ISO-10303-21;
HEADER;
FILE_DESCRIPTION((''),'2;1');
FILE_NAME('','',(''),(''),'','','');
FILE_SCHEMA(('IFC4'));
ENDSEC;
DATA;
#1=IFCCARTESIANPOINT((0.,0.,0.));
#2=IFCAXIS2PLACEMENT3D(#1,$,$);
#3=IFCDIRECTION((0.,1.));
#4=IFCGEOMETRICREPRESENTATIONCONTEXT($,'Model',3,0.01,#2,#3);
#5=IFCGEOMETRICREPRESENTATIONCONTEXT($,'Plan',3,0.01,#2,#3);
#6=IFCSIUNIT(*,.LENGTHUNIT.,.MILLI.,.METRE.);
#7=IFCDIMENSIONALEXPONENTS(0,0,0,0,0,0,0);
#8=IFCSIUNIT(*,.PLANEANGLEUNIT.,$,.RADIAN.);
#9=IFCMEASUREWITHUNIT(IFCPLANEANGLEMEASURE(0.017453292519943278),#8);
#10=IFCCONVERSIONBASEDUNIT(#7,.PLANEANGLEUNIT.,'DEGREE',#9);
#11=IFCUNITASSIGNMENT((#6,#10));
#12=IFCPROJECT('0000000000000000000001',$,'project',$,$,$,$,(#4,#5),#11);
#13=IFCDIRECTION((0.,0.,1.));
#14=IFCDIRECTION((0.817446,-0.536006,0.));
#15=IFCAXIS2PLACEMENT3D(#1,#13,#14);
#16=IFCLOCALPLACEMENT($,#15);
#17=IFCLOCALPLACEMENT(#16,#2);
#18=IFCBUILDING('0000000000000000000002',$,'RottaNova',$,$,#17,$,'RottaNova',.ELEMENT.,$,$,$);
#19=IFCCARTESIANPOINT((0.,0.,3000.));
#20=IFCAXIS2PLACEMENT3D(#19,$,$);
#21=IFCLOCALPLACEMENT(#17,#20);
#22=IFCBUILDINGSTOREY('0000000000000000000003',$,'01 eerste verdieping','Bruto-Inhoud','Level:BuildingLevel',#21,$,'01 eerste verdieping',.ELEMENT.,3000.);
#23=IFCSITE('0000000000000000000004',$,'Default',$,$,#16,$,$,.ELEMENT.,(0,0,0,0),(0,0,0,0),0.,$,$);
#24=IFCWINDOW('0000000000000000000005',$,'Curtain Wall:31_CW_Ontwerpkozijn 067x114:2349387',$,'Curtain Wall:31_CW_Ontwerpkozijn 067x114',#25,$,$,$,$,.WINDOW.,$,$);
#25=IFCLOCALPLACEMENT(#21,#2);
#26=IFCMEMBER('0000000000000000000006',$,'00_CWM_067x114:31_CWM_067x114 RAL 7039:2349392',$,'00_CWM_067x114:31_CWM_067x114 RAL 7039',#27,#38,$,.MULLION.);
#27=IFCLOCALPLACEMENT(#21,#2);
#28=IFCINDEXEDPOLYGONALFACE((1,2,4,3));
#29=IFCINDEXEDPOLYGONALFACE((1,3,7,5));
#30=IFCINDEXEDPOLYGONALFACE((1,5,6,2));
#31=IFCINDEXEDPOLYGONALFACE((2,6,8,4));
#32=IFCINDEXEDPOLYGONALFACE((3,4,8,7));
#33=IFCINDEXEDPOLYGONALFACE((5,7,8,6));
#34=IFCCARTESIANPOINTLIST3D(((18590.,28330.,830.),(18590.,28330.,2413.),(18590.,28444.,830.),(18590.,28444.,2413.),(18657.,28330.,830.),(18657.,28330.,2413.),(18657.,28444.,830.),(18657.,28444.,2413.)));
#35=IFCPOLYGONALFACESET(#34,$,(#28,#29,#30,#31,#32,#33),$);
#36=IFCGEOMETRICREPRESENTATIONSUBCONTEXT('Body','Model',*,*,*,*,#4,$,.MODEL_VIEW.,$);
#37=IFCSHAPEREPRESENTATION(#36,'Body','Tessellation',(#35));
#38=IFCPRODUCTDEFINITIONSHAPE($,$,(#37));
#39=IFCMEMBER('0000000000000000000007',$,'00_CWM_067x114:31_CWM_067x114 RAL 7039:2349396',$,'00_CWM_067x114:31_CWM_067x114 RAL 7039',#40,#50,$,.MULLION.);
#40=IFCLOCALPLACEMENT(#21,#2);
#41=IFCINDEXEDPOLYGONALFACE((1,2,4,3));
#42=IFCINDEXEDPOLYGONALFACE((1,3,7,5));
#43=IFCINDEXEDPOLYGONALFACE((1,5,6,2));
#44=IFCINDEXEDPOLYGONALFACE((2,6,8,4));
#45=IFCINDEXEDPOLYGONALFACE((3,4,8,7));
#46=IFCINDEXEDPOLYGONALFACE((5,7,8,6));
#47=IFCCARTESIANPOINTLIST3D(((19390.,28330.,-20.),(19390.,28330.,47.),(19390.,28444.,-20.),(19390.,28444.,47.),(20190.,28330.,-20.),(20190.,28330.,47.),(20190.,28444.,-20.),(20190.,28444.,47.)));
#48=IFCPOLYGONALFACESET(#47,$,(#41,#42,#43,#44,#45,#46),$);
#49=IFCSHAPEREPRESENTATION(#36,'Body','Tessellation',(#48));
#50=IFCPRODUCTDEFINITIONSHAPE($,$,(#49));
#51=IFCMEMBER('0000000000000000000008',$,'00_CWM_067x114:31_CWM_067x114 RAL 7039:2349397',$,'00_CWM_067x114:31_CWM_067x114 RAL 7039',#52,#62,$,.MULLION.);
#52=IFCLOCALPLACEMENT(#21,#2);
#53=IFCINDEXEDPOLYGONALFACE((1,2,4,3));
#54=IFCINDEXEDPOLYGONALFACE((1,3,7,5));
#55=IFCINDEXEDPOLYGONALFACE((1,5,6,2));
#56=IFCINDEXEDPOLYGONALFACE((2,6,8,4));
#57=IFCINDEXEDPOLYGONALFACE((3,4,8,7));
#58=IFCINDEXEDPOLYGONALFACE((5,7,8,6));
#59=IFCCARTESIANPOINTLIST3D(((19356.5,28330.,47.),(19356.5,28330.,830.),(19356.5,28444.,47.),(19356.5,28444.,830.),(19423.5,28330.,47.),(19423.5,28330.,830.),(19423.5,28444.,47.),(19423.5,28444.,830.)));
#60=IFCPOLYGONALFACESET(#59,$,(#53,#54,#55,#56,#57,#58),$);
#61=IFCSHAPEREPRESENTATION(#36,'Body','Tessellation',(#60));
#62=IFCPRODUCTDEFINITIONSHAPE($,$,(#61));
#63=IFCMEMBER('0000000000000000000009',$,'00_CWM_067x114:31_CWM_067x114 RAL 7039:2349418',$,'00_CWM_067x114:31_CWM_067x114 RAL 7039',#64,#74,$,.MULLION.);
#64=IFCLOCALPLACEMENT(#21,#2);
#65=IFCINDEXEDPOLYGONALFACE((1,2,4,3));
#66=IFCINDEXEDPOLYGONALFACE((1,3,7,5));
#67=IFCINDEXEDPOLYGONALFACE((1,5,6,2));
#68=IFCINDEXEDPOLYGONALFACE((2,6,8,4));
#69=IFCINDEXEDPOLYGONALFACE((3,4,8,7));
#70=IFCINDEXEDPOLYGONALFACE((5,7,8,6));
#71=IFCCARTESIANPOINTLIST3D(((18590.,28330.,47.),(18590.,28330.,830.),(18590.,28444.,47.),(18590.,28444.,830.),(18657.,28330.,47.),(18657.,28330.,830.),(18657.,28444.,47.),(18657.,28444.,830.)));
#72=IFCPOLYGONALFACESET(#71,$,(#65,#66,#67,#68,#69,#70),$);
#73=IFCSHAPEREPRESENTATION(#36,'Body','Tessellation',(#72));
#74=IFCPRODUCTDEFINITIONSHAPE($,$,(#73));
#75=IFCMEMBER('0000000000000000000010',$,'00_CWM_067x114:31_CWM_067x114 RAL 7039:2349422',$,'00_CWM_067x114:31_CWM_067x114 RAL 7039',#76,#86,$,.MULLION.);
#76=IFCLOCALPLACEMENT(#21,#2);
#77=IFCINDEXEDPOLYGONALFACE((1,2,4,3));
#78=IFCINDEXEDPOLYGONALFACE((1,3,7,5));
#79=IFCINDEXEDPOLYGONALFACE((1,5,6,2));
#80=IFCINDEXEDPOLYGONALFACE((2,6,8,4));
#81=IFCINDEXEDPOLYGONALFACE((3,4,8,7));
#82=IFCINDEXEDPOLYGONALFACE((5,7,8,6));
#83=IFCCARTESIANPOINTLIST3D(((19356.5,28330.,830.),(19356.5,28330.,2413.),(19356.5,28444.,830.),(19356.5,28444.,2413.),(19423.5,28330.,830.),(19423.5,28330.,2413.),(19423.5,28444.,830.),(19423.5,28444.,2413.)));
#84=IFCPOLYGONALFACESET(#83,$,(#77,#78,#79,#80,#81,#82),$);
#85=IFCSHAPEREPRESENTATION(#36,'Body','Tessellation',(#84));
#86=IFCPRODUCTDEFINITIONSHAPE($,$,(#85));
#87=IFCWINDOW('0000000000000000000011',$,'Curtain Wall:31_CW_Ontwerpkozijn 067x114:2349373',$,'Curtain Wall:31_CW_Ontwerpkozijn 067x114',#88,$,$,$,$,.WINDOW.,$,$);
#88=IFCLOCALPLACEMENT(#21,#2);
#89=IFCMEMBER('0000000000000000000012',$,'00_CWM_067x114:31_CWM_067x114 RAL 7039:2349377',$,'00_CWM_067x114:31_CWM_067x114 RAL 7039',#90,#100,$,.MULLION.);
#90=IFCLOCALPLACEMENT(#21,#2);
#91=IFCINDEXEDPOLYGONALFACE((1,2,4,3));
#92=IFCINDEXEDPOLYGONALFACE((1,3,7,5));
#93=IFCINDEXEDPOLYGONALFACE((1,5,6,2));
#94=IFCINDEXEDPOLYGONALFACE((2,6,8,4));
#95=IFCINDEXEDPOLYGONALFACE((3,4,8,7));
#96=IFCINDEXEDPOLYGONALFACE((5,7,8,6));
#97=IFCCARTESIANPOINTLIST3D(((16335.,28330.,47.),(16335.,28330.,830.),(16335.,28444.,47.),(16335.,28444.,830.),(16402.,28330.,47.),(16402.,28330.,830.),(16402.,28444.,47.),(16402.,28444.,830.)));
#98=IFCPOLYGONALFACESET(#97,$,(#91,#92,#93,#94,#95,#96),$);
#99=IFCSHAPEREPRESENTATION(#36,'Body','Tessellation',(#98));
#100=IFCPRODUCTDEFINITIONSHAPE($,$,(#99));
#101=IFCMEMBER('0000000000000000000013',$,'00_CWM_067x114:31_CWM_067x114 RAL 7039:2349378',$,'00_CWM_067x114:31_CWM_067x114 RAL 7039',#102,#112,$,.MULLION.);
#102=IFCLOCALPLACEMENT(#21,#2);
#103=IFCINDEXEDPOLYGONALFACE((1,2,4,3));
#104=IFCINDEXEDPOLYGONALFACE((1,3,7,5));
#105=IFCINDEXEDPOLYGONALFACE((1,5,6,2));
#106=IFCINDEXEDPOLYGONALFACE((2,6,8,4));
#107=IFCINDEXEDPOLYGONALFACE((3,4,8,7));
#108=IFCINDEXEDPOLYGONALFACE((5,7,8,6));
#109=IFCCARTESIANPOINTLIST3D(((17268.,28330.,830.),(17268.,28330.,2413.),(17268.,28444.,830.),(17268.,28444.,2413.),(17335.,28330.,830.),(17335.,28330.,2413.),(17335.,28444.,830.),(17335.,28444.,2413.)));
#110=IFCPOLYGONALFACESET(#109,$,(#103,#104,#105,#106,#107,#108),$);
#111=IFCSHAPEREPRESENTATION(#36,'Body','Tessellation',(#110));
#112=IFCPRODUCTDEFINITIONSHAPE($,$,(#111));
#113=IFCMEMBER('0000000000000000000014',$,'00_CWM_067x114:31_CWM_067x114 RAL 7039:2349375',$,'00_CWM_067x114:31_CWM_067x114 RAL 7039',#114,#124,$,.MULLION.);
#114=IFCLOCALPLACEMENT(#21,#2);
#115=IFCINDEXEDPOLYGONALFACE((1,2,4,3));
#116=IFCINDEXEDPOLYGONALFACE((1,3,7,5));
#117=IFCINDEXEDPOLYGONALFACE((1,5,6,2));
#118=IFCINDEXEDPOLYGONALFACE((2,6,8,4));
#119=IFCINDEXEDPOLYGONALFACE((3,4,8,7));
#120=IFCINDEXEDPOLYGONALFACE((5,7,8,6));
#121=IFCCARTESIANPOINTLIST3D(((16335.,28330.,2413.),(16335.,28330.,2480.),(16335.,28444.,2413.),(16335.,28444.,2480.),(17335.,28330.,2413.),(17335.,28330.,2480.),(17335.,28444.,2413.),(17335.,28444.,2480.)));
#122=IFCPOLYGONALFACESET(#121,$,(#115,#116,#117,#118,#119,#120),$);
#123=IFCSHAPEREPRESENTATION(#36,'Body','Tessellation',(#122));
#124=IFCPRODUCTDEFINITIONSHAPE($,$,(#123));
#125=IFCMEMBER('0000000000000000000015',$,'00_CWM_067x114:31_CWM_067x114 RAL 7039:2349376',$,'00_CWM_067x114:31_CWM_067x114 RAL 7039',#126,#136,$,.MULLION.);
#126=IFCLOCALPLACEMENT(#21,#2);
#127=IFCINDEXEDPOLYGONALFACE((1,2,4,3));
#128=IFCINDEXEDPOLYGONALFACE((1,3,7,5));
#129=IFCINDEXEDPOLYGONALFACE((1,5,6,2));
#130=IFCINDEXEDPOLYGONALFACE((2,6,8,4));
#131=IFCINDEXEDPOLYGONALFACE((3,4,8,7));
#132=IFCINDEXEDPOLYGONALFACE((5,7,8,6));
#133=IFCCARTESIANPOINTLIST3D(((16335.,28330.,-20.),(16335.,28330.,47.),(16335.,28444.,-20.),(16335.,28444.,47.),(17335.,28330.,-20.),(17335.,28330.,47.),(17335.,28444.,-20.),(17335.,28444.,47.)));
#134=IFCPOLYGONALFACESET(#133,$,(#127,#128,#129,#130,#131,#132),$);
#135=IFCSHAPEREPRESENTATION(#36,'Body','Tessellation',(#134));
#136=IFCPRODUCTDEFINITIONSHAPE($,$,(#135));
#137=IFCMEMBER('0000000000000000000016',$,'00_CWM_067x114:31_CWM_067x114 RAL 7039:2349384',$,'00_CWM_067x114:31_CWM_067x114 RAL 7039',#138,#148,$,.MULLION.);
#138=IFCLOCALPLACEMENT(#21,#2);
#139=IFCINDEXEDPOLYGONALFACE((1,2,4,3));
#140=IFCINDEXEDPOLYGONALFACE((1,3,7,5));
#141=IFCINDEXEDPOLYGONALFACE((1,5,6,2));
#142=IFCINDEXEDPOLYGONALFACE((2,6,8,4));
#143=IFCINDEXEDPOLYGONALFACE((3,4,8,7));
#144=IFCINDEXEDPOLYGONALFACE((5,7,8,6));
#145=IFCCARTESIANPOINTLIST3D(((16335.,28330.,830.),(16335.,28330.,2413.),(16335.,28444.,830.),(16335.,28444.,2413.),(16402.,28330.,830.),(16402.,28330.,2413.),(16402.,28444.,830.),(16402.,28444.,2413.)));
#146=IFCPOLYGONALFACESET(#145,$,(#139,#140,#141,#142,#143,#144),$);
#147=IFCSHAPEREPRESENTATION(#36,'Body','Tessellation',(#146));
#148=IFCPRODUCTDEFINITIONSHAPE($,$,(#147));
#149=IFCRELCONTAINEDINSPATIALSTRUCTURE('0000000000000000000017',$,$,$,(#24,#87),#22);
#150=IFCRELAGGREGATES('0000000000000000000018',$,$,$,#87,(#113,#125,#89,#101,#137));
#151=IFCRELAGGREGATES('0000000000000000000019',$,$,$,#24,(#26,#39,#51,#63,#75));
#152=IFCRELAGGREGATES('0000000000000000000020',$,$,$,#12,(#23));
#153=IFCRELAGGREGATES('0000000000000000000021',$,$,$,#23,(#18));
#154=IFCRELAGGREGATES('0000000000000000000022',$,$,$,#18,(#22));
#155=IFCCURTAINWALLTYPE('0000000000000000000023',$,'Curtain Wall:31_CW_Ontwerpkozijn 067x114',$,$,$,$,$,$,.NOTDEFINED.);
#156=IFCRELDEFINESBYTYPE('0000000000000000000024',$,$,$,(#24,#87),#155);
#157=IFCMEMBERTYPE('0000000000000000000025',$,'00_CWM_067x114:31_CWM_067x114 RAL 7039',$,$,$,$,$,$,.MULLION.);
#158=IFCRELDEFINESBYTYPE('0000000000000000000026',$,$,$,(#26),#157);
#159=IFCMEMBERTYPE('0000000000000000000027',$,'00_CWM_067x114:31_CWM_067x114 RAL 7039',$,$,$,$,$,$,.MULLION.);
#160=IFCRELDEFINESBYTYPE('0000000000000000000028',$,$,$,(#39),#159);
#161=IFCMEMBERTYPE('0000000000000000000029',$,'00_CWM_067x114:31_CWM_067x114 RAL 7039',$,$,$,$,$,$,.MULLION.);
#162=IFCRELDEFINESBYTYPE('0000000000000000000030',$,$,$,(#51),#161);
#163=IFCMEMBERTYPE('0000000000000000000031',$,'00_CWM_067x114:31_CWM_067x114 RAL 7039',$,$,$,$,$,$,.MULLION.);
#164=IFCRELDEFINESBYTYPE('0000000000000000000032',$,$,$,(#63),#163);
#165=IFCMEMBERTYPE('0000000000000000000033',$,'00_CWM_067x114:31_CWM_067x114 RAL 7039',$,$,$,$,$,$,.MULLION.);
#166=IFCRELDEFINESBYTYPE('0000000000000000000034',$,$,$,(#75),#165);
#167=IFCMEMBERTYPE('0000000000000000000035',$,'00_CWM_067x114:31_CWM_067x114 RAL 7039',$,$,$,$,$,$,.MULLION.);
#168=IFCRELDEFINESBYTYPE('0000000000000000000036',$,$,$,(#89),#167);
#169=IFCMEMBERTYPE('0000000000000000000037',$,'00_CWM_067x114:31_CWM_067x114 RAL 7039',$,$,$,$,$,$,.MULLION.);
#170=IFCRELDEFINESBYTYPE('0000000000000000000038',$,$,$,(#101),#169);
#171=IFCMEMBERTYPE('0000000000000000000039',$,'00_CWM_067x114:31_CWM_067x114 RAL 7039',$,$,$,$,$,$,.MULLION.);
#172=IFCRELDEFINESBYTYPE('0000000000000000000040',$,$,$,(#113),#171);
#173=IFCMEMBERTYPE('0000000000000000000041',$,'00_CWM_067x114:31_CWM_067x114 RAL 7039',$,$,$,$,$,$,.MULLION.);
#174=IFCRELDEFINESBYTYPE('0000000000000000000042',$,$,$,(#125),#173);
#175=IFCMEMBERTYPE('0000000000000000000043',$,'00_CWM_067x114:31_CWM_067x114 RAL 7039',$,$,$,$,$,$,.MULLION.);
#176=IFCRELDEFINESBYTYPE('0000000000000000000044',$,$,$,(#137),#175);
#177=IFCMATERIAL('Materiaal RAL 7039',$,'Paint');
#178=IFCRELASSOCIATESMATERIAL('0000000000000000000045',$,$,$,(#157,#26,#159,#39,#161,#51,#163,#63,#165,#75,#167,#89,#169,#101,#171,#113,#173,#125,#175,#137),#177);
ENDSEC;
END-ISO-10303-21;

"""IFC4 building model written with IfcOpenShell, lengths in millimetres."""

from ifc_helpers import new_model, entity, si_unit, converted_unit, direction, frame, origin, place, context, subcontext, project, spatial, indexed_curve, outline, extrude, source, transform, mapped, material, type_object, type_shapes, element, aggregate, save


model = new_model("IFC4")

# Units and contexts
model_context = context("Model", 3, precision=0.01, world=origin(), true_north=direction((0.0, 1.0)))
plan_context = context("Plan", 3, precision=0.01, world=origin(), true_north=direction((0.0, 1.0)))
body_context = subcontext(model_context, "Body", "Model", "MODEL_VIEW")
ifc_project = project(units=[si_unit("LENGTHUNIT", "METRE", prefix="MILLI"), converted_unit("PLANEANGLEUNIT", "DEGREE", entity("IfcPlaneAngleMeasure", 0.017453292519943278), si_unit("PLANEANGLEUNIT", "RADIAN"), dimensions=[0, 0, 0, 0, 0, 0, 0])], contexts=[model_context, plan_context])

# Site, building, storey
site_placement = place(None, frame((0.0, 0.0, 0.0), z_axis=(0.0, 0.0, 1.0), x_axis=(0.817446, -0.536006, 0.0)))
site = spatial("IfcSite", under=ifc_project, at=site_placement, Name="Default", CompositionType="ELEMENT", RefLatitude=(0, 0, 0, 0), RefLongitude=(0, 0, 0, 0), RefElevation=0.0)
building_placement = place(site_placement, origin())
building = spatial("IfcBuilding", under=site, at=building_placement, Name="RottaNova", LongName="RottaNova", CompositionType="ELEMENT")
storey_placement = place(building_placement, frame((0.0, 0.0, 3000.0)))
storey = spatial("IfcBuildingStorey", under=building, at=storey_placement, Name="01 eerste verdieping", Description="Bruto-Inhoud", ObjectType="Level:BuildingLevel", LongName="01 eerste verdieping", CompositionType="ELEMENT", Elevation=3000.0)

# Windows, members
curtain_wall_type = type_object("IfcCurtainWallType", Name="Curtain Wall:31_CW_Ontwerpkozijn 067x114", PredefinedType="NOTDEFINED")
window_1_placement = place(storey_placement, frame((0.0, 0.0, -3000.0)))
window_1 = element("IfcWindow", 1, at=window_1_placement, inside=storey, type_object=curtain_wall_type, Name="Curtain Wall:31_CW_Ontwerpkozijn 067x114:2349387", ObjectType="Curtain Wall:31_CW_Ontwerpkozijn 067x114", PredefinedType="WINDOW")
ifc_material_1 = material(Name="Materiaal RAL 7039", Category="Paint")
member_type_1 = type_object("IfcMemberType", Name="00_CWM_067x114:31_CWM_067x114 RAL 7039", PredefinedType="MULLION", material=ifc_material_1)
shared_shape_1 = source(origin(), body_context, "Body", "SweptSolid", [
    extrude(outline(indexed_curve([(-33.5, -57.0), (33.5, -57.0), (33.5, 57.0), (-33.5, 57.0), (-33.5, -57.0)], self_intersect=False)), frame((-33.5, -57.0, -1583.0), z_axis=(0.0, 0.0, 1.0), x_axis=(-1.0, 0.0, 0.0)), (0.0, 0.0, 1.0), 1583.0),
])
type_shapes(member_type_1, [shared_shape_1])
member_1_placement = place(window_1_placement, frame((18590.0, 28330.0, 5413.0), z_axis=(0.0, 0.0, 1.0), x_axis=(-1.0, 0.0, 0.0)))
member_1 = element("IfcMember", 2, at=member_1_placement, type_object=member_type_1, material=ifc_material_1, Name="00_CWM_067x114:31_CWM_067x114 RAL 7039:2349392", ObjectType="00_CWM_067x114:31_CWM_067x114 RAL 7039", PredefinedType="MULLION", context=body_context, shape_type="MappedRepresentation", body=[
    mapped(shared_shape_1, transform((0.0, 0.0, 0.0), scale=1.0)),
])
member_type_2 = type_object("IfcMemberType", Name="00_CWM_067x114:31_CWM_067x114 RAL 7039", PredefinedType="MULLION", material=ifc_material_1)
shared_shape_2 = source(origin(), body_context, "Body", "SweptSolid", [
    extrude(outline(indexed_curve([(-33.5, -57.0), (33.5, -57.0), (33.5, 57.0), (-33.5, 57.0), (-33.5, -57.0)], self_intersect=False)), frame((-33.5, -57.0, -800.0), z_axis=(0.0, 0.0, 1.0), x_axis=(-1.0, 0.0, 0.0)), (0.0, 0.0, 1.0), 800.0),
])
type_shapes(member_type_2, [shared_shape_2])
member_2_placement = place(window_1_placement, frame((19390.0, 28330.0, 2980.0), z_axis=(-1.0, 0.0, 0.0), x_axis=(0.0, 0.0, -1.0)))
member_2 = element("IfcMember", 3, at=member_2_placement, type_object=member_type_2, material=ifc_material_1, Name="00_CWM_067x114:31_CWM_067x114 RAL 7039:2349396", ObjectType="00_CWM_067x114:31_CWM_067x114 RAL 7039", PredefinedType="MULLION", context=body_context, shape_type="MappedRepresentation", body=[
    mapped(shared_shape_2, transform((0.0, 0.0, 0.0), scale=1.0)),
])
member_type_3 = type_object("IfcMemberType", Name="00_CWM_067x114:31_CWM_067x114 RAL 7039", PredefinedType="MULLION", material=ifc_material_1)
shared_shape_3 = source(origin(), body_context, "Body", "SweptSolid", [
    extrude(outline(indexed_curve([(-33.5, -57.0), (33.5, -57.0), (33.5, 57.0), (-33.5, 57.0), (-33.5, -57.0)], self_intersect=False)), frame((0.0, -57.0, -783.0), z_axis=(0.0, 0.0, 1.0), x_axis=(-1.0, 0.0, 0.0)), (0.0, 0.0, 1.0), 783.0),
])
type_shapes(member_type_3, [shared_shape_3])
member_3_placement = place(window_1_placement, frame((19390.0, 28330.0, 3047.0), z_axis=(0.0, 0.0, -1.0), x_axis=(1.0, 0.0, 0.0)))
member_3 = element("IfcMember", 4, at=member_3_placement, type_object=member_type_3, material=ifc_material_1, Name="00_CWM_067x114:31_CWM_067x114 RAL 7039:2349397", ObjectType="00_CWM_067x114:31_CWM_067x114 RAL 7039", PredefinedType="MULLION", context=body_context, shape_type="MappedRepresentation", body=[
    mapped(shared_shape_3, transform((0.0, 0.0, 0.0), scale=1.0)),
])
member_type_4 = type_object("IfcMemberType", Name="00_CWM_067x114:31_CWM_067x114 RAL 7039", PredefinedType="MULLION", material=ifc_material_1)
shared_shape_4 = source(origin(), body_context, "Body", "SweptSolid", [
    extrude(outline(indexed_curve([(-33.5, -57.0), (33.5, -57.0), (33.5, 57.0), (-33.5, 57.0), (-33.5, -57.0)], self_intersect=False)), frame((-33.5, -57.0, -783.0), z_axis=(0.0, 0.0, 1.0), x_axis=(-1.0, 0.0, 0.0)), (0.0, 0.0, 1.0), 783.0),
])
type_shapes(member_type_4, [shared_shape_4])
member_4_placement = place(window_1_placement, frame((18590.0, 28330.0, 3830.0), z_axis=(0.0, 0.0, 1.0), x_axis=(-1.0, 0.0, 0.0)))
member_4 = element("IfcMember", 5, at=member_4_placement, type_object=member_type_4, material=ifc_material_1, Name="00_CWM_067x114:31_CWM_067x114 RAL 7039:2349418", ObjectType="00_CWM_067x114:31_CWM_067x114 RAL 7039", PredefinedType="MULLION", context=body_context, shape_type="MappedRepresentation", body=[
    mapped(shared_shape_4, transform((0.0, 0.0, 0.0), scale=1.0)),
])
member_type_5 = type_object("IfcMemberType", Name="00_CWM_067x114:31_CWM_067x114 RAL 7039", PredefinedType="MULLION", material=ifc_material_1)
shared_shape_5 = source(origin(), body_context, "Body", "SweptSolid", [
    extrude(outline(indexed_curve([(-33.5, -57.0), (33.5, -57.0), (33.5, 57.0), (-33.5, 57.0), (-33.5, -57.0)], self_intersect=False)), frame((0.0, -57.0, -1583.0), z_axis=(0.0, 0.0, 1.0), x_axis=(-1.0, 0.0, 0.0)), (0.0, 0.0, 1.0), 1583.0),
])
type_shapes(member_type_5, [shared_shape_5])
member_5_placement = place(window_1_placement, frame((19390.0, 28330.0, 3830.0), z_axis=(0.0, 0.0, -1.0), x_axis=(1.0, 0.0, 0.0)))
member_5 = element("IfcMember", 6, at=member_5_placement, type_object=member_type_5, material=ifc_material_1, Name="00_CWM_067x114:31_CWM_067x114 RAL 7039:2349422", ObjectType="00_CWM_067x114:31_CWM_067x114 RAL 7039", PredefinedType="MULLION", context=body_context, shape_type="MappedRepresentation", body=[
    mapped(shared_shape_5, transform((0.0, 0.0, 0.0), scale=1.0)),
])
window_2_placement = place(storey_placement, frame((0.0, 0.0, -3000.0)))
window_2 = element("IfcWindow", 7, at=window_2_placement, inside=storey, type_object=curtain_wall_type, Name="Curtain Wall:31_CW_Ontwerpkozijn 067x114:2349373", ObjectType="Curtain Wall:31_CW_Ontwerpkozijn 067x114", PredefinedType="WINDOW")
member_type_6 = type_object("IfcMemberType", Name="00_CWM_067x114:31_CWM_067x114 RAL 7039", PredefinedType="MULLION", material=ifc_material_1)
shared_shape_6 = source(origin(), body_context, "Body", "SweptSolid", [
    extrude(outline(indexed_curve([(-33.5, -57.0), (33.5, -57.0), (33.5, 57.0), (-33.5, 57.0), (-33.5, -57.0)], self_intersect=False)), frame((-33.5, 57.0, -783.0), z_axis=(0.0, 0.0, 1.0), x_axis=(-1.0, 0.0, 0.0)), (0.0, 0.0, 1.0), 783.0),
])
type_shapes(member_type_6, [shared_shape_6])
member_6_placement = place(window_2_placement, frame((16335.0, 28330.0, 3047.0), z_axis=(0.0, 0.0, -1.0), x_axis=(-1.0, 0.0, 0.0)))
member_6 = element("IfcMember", 8, at=member_6_placement, type_object=member_type_6, material=ifc_material_1, Name="00_CWM_067x114:31_CWM_067x114 RAL 7039:2349377", ObjectType="00_CWM_067x114:31_CWM_067x114 RAL 7039", PredefinedType="MULLION", context=body_context, shape_type="MappedRepresentation", body=[
    mapped(shared_shape_6, transform((0.0, 0.0, 0.0), scale=1.0)),
])
member_type_7 = type_object("IfcMemberType", Name="00_CWM_067x114:31_CWM_067x114 RAL 7039", PredefinedType="MULLION", material=ifc_material_1)
shared_shape_7 = source(origin(), body_context, "Body", "SweptSolid", [
    extrude(outline(indexed_curve([(-33.5, -57.0), (33.5, -57.0), (33.5, 57.0), (-33.5, 57.0), (-33.5, -57.0)], self_intersect=False)), frame((-33.5, 57.0, -1583.0), z_axis=(0.0, 0.0, 1.0), x_axis=(-1.0, 0.0, 0.0)), (0.0, 0.0, 1.0), 1583.0),
])
type_shapes(member_type_7, [shared_shape_7])
member_7_placement = place(window_2_placement, frame((17335.0, 28330.0, 5413.0)))
member_7 = element("IfcMember", 9, at=member_7_placement, type_object=member_type_7, material=ifc_material_1, Name="00_CWM_067x114:31_CWM_067x114 RAL 7039:2349378", ObjectType="00_CWM_067x114:31_CWM_067x114 RAL 7039", PredefinedType="MULLION", context=body_context, shape_type="MappedRepresentation", body=[
    mapped(shared_shape_7, transform((0.0, 0.0, 0.0), scale=1.0)),
])
member_type_8 = type_object("IfcMemberType", Name="00_CWM_067x114:31_CWM_067x114 RAL 7039", PredefinedType="MULLION", material=ifc_material_1)
shared_shape_8 = source(origin(), body_context, "Body", "SweptSolid", [
    extrude(outline(indexed_curve([(-33.5, -57.0), (33.5, -57.0), (33.5, 57.0), (-33.5, 57.0), (-33.5, -57.0)], self_intersect=False)), frame((-33.5, 57.0, -1000.0), z_axis=(0.0, 0.0, 1.0), x_axis=(-1.0, 0.0, 0.0)), (0.0, 0.0, 1.0), 1000.0),
])
type_shapes(member_type_8, [shared_shape_8])
member_8_placement = place(window_2_placement, frame((16335.0, 28330.0, 5480.0), z_axis=(-1.0, 0.0, 0.0), x_axis=(0.0, 0.0, 1.0)))
member_8 = element("IfcMember", 10, at=member_8_placement, type_object=member_type_8, material=ifc_material_1, Name="00_CWM_067x114:31_CWM_067x114 RAL 7039:2349375", ObjectType="00_CWM_067x114:31_CWM_067x114 RAL 7039", PredefinedType="MULLION", context=body_context, shape_type="MappedRepresentation", body=[
    mapped(shared_shape_8, transform((0.0, 0.0, 0.0), scale=1.0)),
])
member_type_9 = type_object("IfcMemberType", Name="00_CWM_067x114:31_CWM_067x114 RAL 7039", PredefinedType="MULLION", material=ifc_material_1)
shared_shape_9 = source(origin(), body_context, "Body", "SweptSolid", [
    extrude(outline(indexed_curve([(-33.5, -57.0), (33.5, -57.0), (33.5, 57.0), (-33.5, 57.0), (-33.5, -57.0)], self_intersect=False)), frame((-33.5, 57.0, -1000.0), z_axis=(0.0, 0.0, 1.0), x_axis=(-1.0, 0.0, 0.0)), (0.0, 0.0, 1.0), 1000.0),
])
type_shapes(member_type_9, [shared_shape_9])
member_9_placement = place(window_2_placement, frame((17335.0, 28330.0, 2980.0), z_axis=(1.0, 0.0, 0.0), x_axis=(0.0, 0.0, -1.0)))
member_9 = element("IfcMember", 11, at=member_9_placement, type_object=member_type_9, material=ifc_material_1, Name="00_CWM_067x114:31_CWM_067x114 RAL 7039:2349376", ObjectType="00_CWM_067x114:31_CWM_067x114 RAL 7039", PredefinedType="MULLION", context=body_context, shape_type="MappedRepresentation", body=[
    mapped(shared_shape_9, transform((0.0, 0.0, 0.0), scale=1.0)),
])
member_type_10 = type_object("IfcMemberType", Name="00_CWM_067x114:31_CWM_067x114 RAL 7039", PredefinedType="MULLION", material=ifc_material_1)
shared_shape_10 = source(origin(), body_context, "Body", "SweptSolid", [
    extrude(outline(indexed_curve([(-33.5, -57.0), (33.5, -57.0), (33.5, 57.0), (-33.5, 57.0), (-33.5, -57.0)], self_intersect=False)), frame((-33.5, 57.0, -1583.0), z_axis=(0.0, 0.0, 1.0), x_axis=(-1.0, 0.0, 0.0)), (0.0, 0.0, 1.0), 1583.0),
])
type_shapes(member_type_10, [shared_shape_10])
member_10_placement = place(window_2_placement, frame((16335.0, 28330.0, 3830.0), z_axis=(0.0, 0.0, -1.0), x_axis=(-1.0, 0.0, 0.0)))
member_10 = element("IfcMember", 12, at=member_10_placement, type_object=member_type_10, material=ifc_material_1, Name="00_CWM_067x114:31_CWM_067x114 RAL 7039:2349384", ObjectType="00_CWM_067x114:31_CWM_067x114 RAL 7039", PredefinedType="MULLION", context=body_context, shape_type="MappedRepresentation", body=[
    mapped(shared_shape_10, transform((0.0, 0.0, 0.0), scale=1.0)),
])

aggregate(window_2, [member_8, member_9, member_6, member_7, member_10])
aggregate(window_1, [member_1, member_2, member_3, member_4, member_5])

save(model, "model.ifc")
